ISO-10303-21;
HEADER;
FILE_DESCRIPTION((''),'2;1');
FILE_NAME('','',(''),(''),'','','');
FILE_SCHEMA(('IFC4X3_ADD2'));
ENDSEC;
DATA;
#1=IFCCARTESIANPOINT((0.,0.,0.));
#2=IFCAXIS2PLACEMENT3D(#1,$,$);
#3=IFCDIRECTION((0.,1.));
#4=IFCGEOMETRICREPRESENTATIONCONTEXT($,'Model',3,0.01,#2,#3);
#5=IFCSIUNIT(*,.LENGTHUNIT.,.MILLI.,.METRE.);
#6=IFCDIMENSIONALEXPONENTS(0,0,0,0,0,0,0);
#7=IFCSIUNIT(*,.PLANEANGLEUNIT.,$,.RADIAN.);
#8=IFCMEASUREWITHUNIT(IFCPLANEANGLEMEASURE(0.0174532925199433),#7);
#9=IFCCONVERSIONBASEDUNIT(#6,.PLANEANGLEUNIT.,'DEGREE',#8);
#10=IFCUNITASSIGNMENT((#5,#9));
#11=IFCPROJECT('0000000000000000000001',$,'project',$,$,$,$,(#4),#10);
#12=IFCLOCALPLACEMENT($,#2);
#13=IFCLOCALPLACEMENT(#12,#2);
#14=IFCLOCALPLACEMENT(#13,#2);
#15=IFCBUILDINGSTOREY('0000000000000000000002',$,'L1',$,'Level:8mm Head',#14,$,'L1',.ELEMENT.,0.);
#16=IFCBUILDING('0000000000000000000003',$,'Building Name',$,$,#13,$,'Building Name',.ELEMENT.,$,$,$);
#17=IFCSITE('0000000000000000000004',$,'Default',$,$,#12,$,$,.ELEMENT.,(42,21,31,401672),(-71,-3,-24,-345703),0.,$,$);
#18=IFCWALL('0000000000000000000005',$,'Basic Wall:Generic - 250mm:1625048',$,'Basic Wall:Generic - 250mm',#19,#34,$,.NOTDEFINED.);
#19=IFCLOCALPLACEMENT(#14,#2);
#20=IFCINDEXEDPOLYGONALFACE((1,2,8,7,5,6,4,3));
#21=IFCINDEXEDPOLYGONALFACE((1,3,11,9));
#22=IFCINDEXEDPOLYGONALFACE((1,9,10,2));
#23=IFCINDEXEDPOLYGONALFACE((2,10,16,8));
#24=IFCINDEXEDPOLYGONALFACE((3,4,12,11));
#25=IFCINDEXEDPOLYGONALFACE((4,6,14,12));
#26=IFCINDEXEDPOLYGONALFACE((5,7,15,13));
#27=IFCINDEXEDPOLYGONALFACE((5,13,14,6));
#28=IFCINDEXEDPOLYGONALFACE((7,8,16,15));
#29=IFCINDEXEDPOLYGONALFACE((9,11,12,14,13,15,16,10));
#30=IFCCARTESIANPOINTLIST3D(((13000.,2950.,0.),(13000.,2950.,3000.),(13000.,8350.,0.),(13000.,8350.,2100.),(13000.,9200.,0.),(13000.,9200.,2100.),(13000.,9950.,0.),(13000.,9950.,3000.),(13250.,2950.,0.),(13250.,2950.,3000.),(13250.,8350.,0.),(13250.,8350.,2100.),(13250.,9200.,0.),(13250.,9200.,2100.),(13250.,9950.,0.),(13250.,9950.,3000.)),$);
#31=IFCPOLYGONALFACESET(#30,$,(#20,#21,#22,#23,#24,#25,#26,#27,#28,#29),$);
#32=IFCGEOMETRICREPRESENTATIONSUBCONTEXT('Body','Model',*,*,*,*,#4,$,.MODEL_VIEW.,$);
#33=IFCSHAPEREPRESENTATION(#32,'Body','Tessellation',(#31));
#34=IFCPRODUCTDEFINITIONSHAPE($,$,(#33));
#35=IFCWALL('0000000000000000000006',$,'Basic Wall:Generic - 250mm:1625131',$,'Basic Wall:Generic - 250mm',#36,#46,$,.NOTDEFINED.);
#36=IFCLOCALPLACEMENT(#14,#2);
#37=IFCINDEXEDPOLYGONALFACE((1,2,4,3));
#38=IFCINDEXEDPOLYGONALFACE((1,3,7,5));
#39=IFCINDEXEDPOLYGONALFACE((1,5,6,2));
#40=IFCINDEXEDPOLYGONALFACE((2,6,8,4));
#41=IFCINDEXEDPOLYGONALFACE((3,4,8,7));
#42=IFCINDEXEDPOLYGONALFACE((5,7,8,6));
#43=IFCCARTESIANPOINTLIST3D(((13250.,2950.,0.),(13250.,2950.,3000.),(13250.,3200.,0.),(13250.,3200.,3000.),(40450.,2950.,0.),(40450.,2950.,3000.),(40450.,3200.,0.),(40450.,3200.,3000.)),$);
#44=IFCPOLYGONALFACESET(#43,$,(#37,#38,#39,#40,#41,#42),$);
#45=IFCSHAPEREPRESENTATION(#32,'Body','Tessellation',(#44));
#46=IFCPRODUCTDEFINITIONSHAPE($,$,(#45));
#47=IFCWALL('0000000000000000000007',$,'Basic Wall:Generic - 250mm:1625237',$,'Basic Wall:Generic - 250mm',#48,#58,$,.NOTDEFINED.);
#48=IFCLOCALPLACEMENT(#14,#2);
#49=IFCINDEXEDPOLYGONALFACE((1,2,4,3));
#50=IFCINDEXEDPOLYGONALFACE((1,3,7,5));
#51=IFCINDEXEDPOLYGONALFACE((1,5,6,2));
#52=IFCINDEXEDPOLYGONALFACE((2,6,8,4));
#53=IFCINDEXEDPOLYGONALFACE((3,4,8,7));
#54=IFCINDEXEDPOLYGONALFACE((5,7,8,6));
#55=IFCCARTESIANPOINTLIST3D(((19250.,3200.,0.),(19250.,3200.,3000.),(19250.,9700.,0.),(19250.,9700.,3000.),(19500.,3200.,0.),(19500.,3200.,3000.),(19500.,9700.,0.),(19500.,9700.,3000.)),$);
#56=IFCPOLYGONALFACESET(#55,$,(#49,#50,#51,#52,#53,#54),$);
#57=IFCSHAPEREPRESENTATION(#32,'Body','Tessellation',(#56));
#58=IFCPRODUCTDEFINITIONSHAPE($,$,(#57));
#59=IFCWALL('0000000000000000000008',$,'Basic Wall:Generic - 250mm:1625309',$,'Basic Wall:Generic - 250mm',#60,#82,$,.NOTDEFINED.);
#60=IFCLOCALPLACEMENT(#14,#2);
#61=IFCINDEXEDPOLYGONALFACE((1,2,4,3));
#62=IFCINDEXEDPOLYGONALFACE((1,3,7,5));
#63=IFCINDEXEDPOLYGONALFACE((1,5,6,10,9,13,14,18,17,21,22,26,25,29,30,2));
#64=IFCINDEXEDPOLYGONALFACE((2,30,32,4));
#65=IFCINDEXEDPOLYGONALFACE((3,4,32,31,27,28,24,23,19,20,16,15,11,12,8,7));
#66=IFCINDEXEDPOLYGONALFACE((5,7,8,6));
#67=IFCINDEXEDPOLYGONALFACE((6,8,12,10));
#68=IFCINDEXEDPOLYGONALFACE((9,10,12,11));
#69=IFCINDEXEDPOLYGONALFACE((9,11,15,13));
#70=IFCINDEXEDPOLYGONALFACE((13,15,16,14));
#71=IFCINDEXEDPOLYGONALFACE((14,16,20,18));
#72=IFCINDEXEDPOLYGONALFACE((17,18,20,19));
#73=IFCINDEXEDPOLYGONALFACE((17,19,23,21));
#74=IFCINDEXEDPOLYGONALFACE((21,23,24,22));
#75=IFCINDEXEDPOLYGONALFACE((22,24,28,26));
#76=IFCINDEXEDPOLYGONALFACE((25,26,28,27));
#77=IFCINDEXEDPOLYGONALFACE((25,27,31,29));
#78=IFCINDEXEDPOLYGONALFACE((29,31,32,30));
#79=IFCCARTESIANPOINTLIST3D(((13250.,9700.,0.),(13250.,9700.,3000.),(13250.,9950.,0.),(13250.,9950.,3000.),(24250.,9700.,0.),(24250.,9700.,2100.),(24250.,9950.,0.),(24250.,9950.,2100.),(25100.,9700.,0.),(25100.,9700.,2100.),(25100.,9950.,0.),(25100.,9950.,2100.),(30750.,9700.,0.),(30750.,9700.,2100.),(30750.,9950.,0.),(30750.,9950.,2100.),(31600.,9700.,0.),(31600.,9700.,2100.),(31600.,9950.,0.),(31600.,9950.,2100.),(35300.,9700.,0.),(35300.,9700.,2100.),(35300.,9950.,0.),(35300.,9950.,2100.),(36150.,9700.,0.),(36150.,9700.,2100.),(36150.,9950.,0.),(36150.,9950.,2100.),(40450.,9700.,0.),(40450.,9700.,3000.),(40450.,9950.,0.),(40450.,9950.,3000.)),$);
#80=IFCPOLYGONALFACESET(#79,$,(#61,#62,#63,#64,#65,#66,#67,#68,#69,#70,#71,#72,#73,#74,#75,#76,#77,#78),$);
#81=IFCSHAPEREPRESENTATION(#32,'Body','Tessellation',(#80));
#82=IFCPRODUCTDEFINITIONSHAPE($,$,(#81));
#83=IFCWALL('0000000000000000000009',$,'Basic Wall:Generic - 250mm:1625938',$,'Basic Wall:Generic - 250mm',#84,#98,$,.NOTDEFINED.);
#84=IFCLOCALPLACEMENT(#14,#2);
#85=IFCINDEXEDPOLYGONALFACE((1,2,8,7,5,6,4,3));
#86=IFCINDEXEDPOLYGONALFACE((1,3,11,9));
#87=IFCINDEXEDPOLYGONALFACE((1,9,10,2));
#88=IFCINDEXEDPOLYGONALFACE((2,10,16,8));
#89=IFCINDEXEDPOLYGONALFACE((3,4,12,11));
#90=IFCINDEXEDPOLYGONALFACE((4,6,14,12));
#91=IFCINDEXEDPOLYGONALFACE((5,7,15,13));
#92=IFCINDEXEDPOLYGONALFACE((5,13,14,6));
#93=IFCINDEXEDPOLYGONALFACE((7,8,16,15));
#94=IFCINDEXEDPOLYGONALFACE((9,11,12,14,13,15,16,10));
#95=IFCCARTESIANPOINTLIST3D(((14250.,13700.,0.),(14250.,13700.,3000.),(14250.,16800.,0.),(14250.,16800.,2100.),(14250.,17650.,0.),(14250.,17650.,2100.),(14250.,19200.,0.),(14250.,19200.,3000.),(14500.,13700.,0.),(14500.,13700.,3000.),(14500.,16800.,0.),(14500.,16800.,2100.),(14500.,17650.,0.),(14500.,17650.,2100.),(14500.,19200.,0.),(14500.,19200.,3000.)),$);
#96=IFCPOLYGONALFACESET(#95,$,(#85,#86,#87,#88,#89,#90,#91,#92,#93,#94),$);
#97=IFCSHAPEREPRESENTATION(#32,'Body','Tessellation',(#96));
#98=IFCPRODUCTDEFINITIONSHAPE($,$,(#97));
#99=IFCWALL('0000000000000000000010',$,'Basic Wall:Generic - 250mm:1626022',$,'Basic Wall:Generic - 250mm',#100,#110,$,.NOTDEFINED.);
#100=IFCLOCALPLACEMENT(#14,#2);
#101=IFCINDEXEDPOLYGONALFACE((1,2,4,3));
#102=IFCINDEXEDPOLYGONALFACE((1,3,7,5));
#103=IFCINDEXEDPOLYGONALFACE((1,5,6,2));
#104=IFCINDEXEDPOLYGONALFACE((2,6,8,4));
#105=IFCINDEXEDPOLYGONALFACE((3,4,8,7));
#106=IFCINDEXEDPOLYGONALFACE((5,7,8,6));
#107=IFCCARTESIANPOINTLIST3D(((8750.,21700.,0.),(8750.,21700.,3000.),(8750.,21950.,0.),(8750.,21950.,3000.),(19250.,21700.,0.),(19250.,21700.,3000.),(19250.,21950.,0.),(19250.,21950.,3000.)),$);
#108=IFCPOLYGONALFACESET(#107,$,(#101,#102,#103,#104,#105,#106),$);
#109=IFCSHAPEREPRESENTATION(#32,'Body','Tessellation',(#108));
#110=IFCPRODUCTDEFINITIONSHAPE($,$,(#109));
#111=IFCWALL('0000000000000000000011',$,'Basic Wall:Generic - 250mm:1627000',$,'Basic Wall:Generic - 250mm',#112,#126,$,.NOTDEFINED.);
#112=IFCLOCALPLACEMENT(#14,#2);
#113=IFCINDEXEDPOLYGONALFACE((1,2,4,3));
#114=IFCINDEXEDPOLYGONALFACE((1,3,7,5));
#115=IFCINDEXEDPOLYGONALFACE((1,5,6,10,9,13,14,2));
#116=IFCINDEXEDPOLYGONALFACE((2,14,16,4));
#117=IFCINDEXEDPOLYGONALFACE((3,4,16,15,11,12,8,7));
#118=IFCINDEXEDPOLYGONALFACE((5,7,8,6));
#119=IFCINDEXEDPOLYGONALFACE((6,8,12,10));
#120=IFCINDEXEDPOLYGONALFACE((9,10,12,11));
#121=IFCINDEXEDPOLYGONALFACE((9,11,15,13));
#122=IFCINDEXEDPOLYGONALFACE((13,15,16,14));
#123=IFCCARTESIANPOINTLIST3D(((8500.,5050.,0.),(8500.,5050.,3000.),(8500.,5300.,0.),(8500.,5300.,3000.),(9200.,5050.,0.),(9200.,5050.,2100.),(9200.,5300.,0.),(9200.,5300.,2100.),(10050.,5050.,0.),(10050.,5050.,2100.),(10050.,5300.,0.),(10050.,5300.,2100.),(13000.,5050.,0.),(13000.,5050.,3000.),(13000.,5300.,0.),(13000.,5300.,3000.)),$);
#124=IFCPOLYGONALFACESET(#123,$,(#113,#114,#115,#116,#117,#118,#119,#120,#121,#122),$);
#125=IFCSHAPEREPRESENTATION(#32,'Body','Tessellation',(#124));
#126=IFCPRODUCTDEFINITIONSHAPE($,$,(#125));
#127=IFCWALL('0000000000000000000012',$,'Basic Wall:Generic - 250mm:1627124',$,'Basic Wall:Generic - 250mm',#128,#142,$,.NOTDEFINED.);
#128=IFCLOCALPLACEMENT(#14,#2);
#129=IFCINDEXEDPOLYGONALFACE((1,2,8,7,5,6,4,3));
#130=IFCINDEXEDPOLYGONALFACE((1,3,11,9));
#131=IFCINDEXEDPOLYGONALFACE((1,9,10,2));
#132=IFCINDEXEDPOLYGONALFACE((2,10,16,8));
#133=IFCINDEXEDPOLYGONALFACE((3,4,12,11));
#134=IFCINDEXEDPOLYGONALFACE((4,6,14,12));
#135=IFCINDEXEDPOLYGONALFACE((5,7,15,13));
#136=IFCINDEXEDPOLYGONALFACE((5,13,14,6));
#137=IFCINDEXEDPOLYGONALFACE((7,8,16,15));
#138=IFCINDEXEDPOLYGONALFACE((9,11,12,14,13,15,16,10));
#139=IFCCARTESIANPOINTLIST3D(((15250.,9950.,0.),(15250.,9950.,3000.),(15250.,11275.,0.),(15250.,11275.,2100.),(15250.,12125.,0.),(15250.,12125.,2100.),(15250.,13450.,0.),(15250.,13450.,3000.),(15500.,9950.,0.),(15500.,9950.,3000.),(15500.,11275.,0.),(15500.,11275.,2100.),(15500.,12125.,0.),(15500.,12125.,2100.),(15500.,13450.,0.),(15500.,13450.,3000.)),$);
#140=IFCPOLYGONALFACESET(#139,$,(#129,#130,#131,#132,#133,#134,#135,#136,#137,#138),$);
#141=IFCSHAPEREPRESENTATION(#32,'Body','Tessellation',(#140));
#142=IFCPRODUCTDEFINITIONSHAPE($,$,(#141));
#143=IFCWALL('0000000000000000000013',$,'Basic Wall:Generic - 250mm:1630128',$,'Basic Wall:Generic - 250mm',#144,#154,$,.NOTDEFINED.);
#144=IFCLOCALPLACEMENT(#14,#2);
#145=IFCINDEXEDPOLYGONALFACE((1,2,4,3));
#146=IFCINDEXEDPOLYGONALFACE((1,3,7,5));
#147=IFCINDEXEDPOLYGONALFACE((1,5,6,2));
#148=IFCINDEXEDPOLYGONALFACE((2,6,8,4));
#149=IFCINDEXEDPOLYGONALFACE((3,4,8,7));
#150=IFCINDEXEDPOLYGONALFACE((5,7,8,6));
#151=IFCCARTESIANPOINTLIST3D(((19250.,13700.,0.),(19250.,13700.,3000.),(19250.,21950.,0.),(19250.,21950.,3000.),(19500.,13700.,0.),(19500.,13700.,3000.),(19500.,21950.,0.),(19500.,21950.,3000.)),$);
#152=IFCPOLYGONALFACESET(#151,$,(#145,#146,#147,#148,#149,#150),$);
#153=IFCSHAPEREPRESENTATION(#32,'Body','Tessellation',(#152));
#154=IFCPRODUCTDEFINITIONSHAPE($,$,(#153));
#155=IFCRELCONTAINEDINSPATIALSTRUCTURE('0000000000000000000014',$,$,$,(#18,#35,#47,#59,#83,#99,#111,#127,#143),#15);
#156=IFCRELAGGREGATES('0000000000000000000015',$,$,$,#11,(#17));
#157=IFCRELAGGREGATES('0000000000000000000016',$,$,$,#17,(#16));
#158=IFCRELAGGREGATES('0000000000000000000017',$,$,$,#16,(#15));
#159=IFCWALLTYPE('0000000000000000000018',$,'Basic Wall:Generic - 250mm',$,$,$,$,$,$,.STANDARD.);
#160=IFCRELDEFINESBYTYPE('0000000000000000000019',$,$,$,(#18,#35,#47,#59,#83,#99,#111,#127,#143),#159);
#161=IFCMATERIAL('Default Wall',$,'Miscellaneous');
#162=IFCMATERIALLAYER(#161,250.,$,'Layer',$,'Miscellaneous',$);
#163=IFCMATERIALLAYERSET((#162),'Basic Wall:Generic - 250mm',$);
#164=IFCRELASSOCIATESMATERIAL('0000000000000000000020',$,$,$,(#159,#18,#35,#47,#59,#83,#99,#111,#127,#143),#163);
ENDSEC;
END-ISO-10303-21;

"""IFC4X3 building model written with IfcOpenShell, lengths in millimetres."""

from ifc_helpers import new_model, entity, si_unit, converted_unit, direction, frame, frame_2d, origin, place, context, subcontext, project, spatial, rectangle, extrude, material, layer, layer_set, type_object, element, save


model = new_model("IFC4X3")

# Units and contexts
model_context = context("Model", 3, precision=0.01, world=origin(), true_north=direction((0.0, 1.0)))
body_context = subcontext(model_context, "Body", "Model", "MODEL_VIEW")
ifc_project = project(units=[si_unit("LENGTHUNIT", "METRE", prefix="MILLI"), converted_unit("PLANEANGLEUNIT", "DEGREE", entity("IfcPlaneAngleMeasure", 0.0174532925199433), si_unit("PLANEANGLEUNIT", "RADIAN"), dimensions=[0, 0, 0, 0, 0, 0, 0])], contexts=[model_context])

# Site, building, storey
site_placement = place(None, origin())
site = spatial("IfcSite", under=ifc_project, at=site_placement, Name="Default", CompositionType="ELEMENT", RefLatitude=(42, 21, 31, 401672), RefLongitude=(-71, -3, -24, -345703), RefElevation=0.0)
building_placement = place(site_placement, origin())
building = spatial("IfcBuilding", under=site, at=building_placement, Name="Building Name", LongName="Building Name", CompositionType="ELEMENT")
storey_placement = place(building_placement, origin())
storey = spatial("IfcBuildingStorey", under=building, at=storey_placement, Name="L1", ObjectType="Level:8mm Head", LongName="L1", CompositionType="ELEMENT", Elevation=0.0)

# Wall, opening
ifc_material = material(Name="Default Wall", Category="Miscellaneous")
ifc_layer = layer(ifc_material, 250.0, Name="Layer", Category="Miscellaneous")
ifc_layer_set = layer_set([ifc_layer], Name="Basic Wall:Generic - 250mm")
wall_type = type_object("IfcWallType", Name="Basic Wall:Generic - 250mm", PredefinedType="STANDARD", material=ifc_layer_set)
wall_1_placement = place(storey_placement, frame((13125.0, 9950.0, 0.0), z_axis=(0.0, 0.0, 1.0), x_axis=(0.0, -1.0, 0.0)))
wall_1 = element("IfcWall", 1, at=wall_1_placement, inside=storey, type_object=wall_type, material=ifc_layer_set, Name="Basic Wall:Generic - 250mm:1625048", ObjectType="Basic Wall:Generic - 250mm", PredefinedType="NOTDEFINED", context=body_context, shape_type="SweptSolid", body=[
    extrude(rectangle(XDim=7000.0, YDim=250.0, at=frame_2d((3500.0, 0.0), x_axis=(-1.0, 0.0))), origin(), (0.0, 0.0, 1.0), 3000.0),
])
opening_1_placement = place(wall_1_placement, frame((750.0, -125.0, 0.0)))
element("IfcOpeningElement", 2, at=opening_1_placement, cuts=wall_1, PredefinedType="OPENING", context=body_context, shape_type="SweptSolid", body=[
    extrude(rectangle(XDim=2100.0, YDim=850.0, at=frame_2d((1050.0, 425.0), x_axis=(1.0, 0.0))), frame((0.0, 0.0, 0.0), z_axis=(0.0, 1.0, 0.0), x_axis=(0.0, 0.0, 1.0)), (0.0, 0.0, 1.0), 250.0),
])

# Walls
wall_2_placement = place(storey_placement, frame((13250.0, 3075.0, 0.0)))
element("IfcWall", 3, at=wall_2_placement, inside=storey, type_object=wall_type, material=ifc_layer_set, Name="Basic Wall:Generic - 250mm:1625131", ObjectType="Basic Wall:Generic - 250mm", PredefinedType="NOTDEFINED", context=body_context, shape_type="SweptSolid", body=[
    extrude(rectangle(XDim=27200.0, YDim=250.0, at=frame_2d((13600.0, 0.0), x_axis=(-1.0, 0.0))), origin(), (0.0, 0.0, 1.0), 3000.0),
])
wall_3_placement = place(storey_placement, frame((19375.0, 3200.0, 0.0), z_axis=(0.0, 0.0, 1.0), x_axis=(0.0, 1.0, 0.0)))
element("IfcWall", 4, at=wall_3_placement, inside=storey, type_object=wall_type, material=ifc_layer_set, Name="Basic Wall:Generic - 250mm:1625237", ObjectType="Basic Wall:Generic - 250mm", PredefinedType="NOTDEFINED", context=body_context, shape_type="SweptSolid", body=[
    extrude(rectangle(XDim=6500.0, YDim=250.0, at=frame_2d((3250.0, 0.0), x_axis=(-1.0, 0.0))), origin(), (0.0, 0.0, 1.0), 3000.0),
])

# Wall, openings
wall_4_placement = place(storey_placement, frame((40450.0, 9825.0, 0.0), z_axis=(0.0, 0.0, 1.0), x_axis=(-1.0, 0.0, 0.0)))
wall_4 = element("IfcWall", 5, at=wall_4_placement, inside=storey, type_object=wall_type, material=ifc_layer_set, Name="Basic Wall:Generic - 250mm:1625309", ObjectType="Basic Wall:Generic - 250mm", PredefinedType="NOTDEFINED", context=body_context, shape_type="SweptSolid", body=[
    extrude(rectangle(XDim=27200.0, YDim=250.0, at=frame_2d((13600.0, 0.0), x_axis=(1.0, 0.0))), origin(), (0.0, 0.0, 1.0), 3000.0),
])
opening_2_placement = place(wall_4_placement, frame((15350.0, -125.0, 0.0)))
element("IfcOpeningElement", 6, at=opening_2_placement, cuts=wall_4, PredefinedType="OPENING", context=body_context, shape_type="SweptSolid", body=[
    extrude(rectangle(XDim=2100.0, YDim=850.0, at=frame_2d((1050.0, 425.0), x_axis=(1.0, 0.0))), frame((0.0, 0.0, 0.0), z_axis=(0.0, 1.0, 0.0), x_axis=(0.0, 0.0, 1.0)), (0.0, 0.0, 1.0), 250.0),
])
opening_3_placement = place(wall_4_placement, frame((8850.0, -125.0, 0.0)))
element("IfcOpeningElement", 7, at=opening_3_placement, cuts=wall_4, PredefinedType="OPENING", context=body_context, shape_type="SweptSolid", body=[
    extrude(rectangle(XDim=2100.0, YDim=850.0, at=frame_2d((1050.0, 425.0), x_axis=(1.0, 0.0))), frame((0.0, 0.0, 0.0), z_axis=(0.0, 1.0, 0.0), x_axis=(0.0, 0.0, 1.0)), (0.0, 0.0, 1.0), 250.0),
])
opening_4_placement = place(wall_4_placement, frame((4300.0, -125.0, 0.0)))
element("IfcOpeningElement", 8, at=opening_4_placement, cuts=wall_4, PredefinedType="OPENING", context=body_context, shape_type="SweptSolid", body=[
    extrude(rectangle(XDim=2100.0, YDim=850.0, at=frame_2d((1050.0, 425.0), x_axis=(1.0, 0.0))), frame((0.0, 0.0, 0.0), z_axis=(0.0, 1.0, 0.0), x_axis=(0.0, 0.0, 1.0)), (0.0, 0.0, 1.0), 250.0),
])

# Wall, opening
wall_5_placement = place(storey_placement, frame((14375.0, 13700.0, 0.0), z_axis=(0.0, 0.0, 1.0), x_axis=(0.0, 1.0, 0.0)))
wall_5 = element("IfcWall", 9, at=wall_5_placement, inside=storey, type_object=wall_type, material=ifc_layer_set, Name="Basic Wall:Generic - 250mm:1625938", ObjectType="Basic Wall:Generic - 250mm", PredefinedType="NOTDEFINED", context=body_context, shape_type="SweptSolid", body=[
    extrude(rectangle(XDim=5500.0, YDim=250.0, at=frame_2d((2750.0, 0.0), x_axis=(1.0, 0.0))), origin(), (0.0, 0.0, 1.0), 3000.0),
])
opening_5_placement = place(wall_5_placement, frame((3950.0, 125.0, 0.0)))
element("IfcOpeningElement", 10, at=opening_5_placement, cuts=wall_5, PredefinedType="OPENING", context=body_context, shape_type="SweptSolid", body=[
    extrude(rectangle(XDim=2100.0, YDim=850.0, at=frame_2d((1050.0, 425.0), x_axis=(1.0, 0.0))), frame((0.0, 0.0, 0.0), z_axis=(0.0, -1.0, 0.0), x_axis=(0.0, 0.0, 1.0)), (0.0, 0.0, 1.0), 250.0),
])

# Wall
wall_6_placement = place(storey_placement, frame((19250.0, 21825.0, 0.0), z_axis=(0.0, 0.0, 1.0), x_axis=(-1.0, 0.0, 0.0)))
element("IfcWall", 11, at=wall_6_placement, inside=storey, type_object=wall_type, material=ifc_layer_set, Name="Basic Wall:Generic - 250mm:1626022", ObjectType="Basic Wall:Generic - 250mm", PredefinedType="NOTDEFINED", context=body_context, shape_type="SweptSolid", body=[
    extrude(rectangle(XDim=10500.0, YDim=250.0, at=frame_2d((5250.0, 0.0), x_axis=(-1.0, 0.0))), origin(), (0.0, 0.0, 1.0), 3000.0),
])

# Walls, openings
wall_7_placement = place(storey_placement, frame((13000.0, 5175.0, 0.0), z_axis=(0.0, 0.0, 1.0), x_axis=(-1.0, 0.0, 0.0)))
wall_7 = element("IfcWall", 12, at=wall_7_placement, inside=storey, type_object=wall_type, material=ifc_layer_set, Name="Basic Wall:Generic - 250mm:1627000", ObjectType="Basic Wall:Generic - 250mm", PredefinedType="NOTDEFINED", context=body_context, shape_type="SweptSolid", body=[
    extrude(rectangle(XDim=4500.0, YDim=250.0, at=frame_2d((2250.0, 0.0), x_axis=(-1.0, 0.0))), origin(), (0.0, 0.0, 1.0), 3000.0),
])
opening_6_placement = place(wall_7_placement, frame((3800.0, 125.0, 0.0)))
element("IfcOpeningElement", 13, at=opening_6_placement, cuts=wall_7, PredefinedType="OPENING", context=body_context, shape_type="SweptSolid", body=[
    extrude(rectangle(XDim=2100.0, YDim=850.0, at=frame_2d((1050.0, 425.0), x_axis=(1.0, 0.0))), frame((0.0, 0.0, 0.0), z_axis=(0.0, -1.0, 0.0), x_axis=(0.0, 0.0, 1.0)), (0.0, 0.0, 1.0), 250.0),
])
wall_8_placement = place(storey_placement, frame((15375.0, 13450.0, 0.0), z_axis=(0.0, 0.0, 1.0), x_axis=(0.0, -1.0, 0.0)))
wall_8 = element("IfcWall", 14, at=wall_8_placement, inside=storey, type_object=wall_type, material=ifc_layer_set, Name="Basic Wall:Generic - 250mm:1627124", ObjectType="Basic Wall:Generic - 250mm", PredefinedType="NOTDEFINED", context=body_context, shape_type="SweptSolid", body=[
    extrude(rectangle(XDim=3500.0, YDim=250.0, at=frame_2d((1750.0, 0.0), x_axis=(1.0, 0.0))), origin(), (0.0, 0.0, 1.0), 3000.0),
])
opening_7_placement = place(wall_8_placement, frame((1325.0, -125.0, 0.0)))
element("IfcOpeningElement", 15, at=opening_7_placement, cuts=wall_8, PredefinedType="OPENING", context=body_context, shape_type="SweptSolid", body=[
    extrude(rectangle(XDim=2100.0, YDim=850.0, at=frame_2d((1050.0, 425.0), x_axis=(1.0, 0.0))), frame((0.0, 0.0, 0.0), z_axis=(0.0, 1.0, 0.0), x_axis=(0.0, 0.0, 1.0)), (0.0, 0.0, 1.0), 250.0),
])

# Wall
wall_9_placement = place(storey_placement, frame((19375.0, 13700.0, 0.0), z_axis=(0.0, 0.0, 1.0), x_axis=(0.0, 1.0, 0.0)))
element("IfcWall", 16, at=wall_9_placement, inside=storey, type_object=wall_type, material=ifc_layer_set, Name="Basic Wall:Generic - 250mm:1630128", ObjectType="Basic Wall:Generic - 250mm", PredefinedType="NOTDEFINED", context=body_context, shape_type="SweptSolid", body=[
    extrude(rectangle(XDim=8250.0, YDim=250.0, at=frame_2d((4125.0, 0.0), x_axis=(-1.0, 0.0))), origin(), (0.0, 0.0, 1.0), 3000.0),
])

save(model, "model.ifc")
